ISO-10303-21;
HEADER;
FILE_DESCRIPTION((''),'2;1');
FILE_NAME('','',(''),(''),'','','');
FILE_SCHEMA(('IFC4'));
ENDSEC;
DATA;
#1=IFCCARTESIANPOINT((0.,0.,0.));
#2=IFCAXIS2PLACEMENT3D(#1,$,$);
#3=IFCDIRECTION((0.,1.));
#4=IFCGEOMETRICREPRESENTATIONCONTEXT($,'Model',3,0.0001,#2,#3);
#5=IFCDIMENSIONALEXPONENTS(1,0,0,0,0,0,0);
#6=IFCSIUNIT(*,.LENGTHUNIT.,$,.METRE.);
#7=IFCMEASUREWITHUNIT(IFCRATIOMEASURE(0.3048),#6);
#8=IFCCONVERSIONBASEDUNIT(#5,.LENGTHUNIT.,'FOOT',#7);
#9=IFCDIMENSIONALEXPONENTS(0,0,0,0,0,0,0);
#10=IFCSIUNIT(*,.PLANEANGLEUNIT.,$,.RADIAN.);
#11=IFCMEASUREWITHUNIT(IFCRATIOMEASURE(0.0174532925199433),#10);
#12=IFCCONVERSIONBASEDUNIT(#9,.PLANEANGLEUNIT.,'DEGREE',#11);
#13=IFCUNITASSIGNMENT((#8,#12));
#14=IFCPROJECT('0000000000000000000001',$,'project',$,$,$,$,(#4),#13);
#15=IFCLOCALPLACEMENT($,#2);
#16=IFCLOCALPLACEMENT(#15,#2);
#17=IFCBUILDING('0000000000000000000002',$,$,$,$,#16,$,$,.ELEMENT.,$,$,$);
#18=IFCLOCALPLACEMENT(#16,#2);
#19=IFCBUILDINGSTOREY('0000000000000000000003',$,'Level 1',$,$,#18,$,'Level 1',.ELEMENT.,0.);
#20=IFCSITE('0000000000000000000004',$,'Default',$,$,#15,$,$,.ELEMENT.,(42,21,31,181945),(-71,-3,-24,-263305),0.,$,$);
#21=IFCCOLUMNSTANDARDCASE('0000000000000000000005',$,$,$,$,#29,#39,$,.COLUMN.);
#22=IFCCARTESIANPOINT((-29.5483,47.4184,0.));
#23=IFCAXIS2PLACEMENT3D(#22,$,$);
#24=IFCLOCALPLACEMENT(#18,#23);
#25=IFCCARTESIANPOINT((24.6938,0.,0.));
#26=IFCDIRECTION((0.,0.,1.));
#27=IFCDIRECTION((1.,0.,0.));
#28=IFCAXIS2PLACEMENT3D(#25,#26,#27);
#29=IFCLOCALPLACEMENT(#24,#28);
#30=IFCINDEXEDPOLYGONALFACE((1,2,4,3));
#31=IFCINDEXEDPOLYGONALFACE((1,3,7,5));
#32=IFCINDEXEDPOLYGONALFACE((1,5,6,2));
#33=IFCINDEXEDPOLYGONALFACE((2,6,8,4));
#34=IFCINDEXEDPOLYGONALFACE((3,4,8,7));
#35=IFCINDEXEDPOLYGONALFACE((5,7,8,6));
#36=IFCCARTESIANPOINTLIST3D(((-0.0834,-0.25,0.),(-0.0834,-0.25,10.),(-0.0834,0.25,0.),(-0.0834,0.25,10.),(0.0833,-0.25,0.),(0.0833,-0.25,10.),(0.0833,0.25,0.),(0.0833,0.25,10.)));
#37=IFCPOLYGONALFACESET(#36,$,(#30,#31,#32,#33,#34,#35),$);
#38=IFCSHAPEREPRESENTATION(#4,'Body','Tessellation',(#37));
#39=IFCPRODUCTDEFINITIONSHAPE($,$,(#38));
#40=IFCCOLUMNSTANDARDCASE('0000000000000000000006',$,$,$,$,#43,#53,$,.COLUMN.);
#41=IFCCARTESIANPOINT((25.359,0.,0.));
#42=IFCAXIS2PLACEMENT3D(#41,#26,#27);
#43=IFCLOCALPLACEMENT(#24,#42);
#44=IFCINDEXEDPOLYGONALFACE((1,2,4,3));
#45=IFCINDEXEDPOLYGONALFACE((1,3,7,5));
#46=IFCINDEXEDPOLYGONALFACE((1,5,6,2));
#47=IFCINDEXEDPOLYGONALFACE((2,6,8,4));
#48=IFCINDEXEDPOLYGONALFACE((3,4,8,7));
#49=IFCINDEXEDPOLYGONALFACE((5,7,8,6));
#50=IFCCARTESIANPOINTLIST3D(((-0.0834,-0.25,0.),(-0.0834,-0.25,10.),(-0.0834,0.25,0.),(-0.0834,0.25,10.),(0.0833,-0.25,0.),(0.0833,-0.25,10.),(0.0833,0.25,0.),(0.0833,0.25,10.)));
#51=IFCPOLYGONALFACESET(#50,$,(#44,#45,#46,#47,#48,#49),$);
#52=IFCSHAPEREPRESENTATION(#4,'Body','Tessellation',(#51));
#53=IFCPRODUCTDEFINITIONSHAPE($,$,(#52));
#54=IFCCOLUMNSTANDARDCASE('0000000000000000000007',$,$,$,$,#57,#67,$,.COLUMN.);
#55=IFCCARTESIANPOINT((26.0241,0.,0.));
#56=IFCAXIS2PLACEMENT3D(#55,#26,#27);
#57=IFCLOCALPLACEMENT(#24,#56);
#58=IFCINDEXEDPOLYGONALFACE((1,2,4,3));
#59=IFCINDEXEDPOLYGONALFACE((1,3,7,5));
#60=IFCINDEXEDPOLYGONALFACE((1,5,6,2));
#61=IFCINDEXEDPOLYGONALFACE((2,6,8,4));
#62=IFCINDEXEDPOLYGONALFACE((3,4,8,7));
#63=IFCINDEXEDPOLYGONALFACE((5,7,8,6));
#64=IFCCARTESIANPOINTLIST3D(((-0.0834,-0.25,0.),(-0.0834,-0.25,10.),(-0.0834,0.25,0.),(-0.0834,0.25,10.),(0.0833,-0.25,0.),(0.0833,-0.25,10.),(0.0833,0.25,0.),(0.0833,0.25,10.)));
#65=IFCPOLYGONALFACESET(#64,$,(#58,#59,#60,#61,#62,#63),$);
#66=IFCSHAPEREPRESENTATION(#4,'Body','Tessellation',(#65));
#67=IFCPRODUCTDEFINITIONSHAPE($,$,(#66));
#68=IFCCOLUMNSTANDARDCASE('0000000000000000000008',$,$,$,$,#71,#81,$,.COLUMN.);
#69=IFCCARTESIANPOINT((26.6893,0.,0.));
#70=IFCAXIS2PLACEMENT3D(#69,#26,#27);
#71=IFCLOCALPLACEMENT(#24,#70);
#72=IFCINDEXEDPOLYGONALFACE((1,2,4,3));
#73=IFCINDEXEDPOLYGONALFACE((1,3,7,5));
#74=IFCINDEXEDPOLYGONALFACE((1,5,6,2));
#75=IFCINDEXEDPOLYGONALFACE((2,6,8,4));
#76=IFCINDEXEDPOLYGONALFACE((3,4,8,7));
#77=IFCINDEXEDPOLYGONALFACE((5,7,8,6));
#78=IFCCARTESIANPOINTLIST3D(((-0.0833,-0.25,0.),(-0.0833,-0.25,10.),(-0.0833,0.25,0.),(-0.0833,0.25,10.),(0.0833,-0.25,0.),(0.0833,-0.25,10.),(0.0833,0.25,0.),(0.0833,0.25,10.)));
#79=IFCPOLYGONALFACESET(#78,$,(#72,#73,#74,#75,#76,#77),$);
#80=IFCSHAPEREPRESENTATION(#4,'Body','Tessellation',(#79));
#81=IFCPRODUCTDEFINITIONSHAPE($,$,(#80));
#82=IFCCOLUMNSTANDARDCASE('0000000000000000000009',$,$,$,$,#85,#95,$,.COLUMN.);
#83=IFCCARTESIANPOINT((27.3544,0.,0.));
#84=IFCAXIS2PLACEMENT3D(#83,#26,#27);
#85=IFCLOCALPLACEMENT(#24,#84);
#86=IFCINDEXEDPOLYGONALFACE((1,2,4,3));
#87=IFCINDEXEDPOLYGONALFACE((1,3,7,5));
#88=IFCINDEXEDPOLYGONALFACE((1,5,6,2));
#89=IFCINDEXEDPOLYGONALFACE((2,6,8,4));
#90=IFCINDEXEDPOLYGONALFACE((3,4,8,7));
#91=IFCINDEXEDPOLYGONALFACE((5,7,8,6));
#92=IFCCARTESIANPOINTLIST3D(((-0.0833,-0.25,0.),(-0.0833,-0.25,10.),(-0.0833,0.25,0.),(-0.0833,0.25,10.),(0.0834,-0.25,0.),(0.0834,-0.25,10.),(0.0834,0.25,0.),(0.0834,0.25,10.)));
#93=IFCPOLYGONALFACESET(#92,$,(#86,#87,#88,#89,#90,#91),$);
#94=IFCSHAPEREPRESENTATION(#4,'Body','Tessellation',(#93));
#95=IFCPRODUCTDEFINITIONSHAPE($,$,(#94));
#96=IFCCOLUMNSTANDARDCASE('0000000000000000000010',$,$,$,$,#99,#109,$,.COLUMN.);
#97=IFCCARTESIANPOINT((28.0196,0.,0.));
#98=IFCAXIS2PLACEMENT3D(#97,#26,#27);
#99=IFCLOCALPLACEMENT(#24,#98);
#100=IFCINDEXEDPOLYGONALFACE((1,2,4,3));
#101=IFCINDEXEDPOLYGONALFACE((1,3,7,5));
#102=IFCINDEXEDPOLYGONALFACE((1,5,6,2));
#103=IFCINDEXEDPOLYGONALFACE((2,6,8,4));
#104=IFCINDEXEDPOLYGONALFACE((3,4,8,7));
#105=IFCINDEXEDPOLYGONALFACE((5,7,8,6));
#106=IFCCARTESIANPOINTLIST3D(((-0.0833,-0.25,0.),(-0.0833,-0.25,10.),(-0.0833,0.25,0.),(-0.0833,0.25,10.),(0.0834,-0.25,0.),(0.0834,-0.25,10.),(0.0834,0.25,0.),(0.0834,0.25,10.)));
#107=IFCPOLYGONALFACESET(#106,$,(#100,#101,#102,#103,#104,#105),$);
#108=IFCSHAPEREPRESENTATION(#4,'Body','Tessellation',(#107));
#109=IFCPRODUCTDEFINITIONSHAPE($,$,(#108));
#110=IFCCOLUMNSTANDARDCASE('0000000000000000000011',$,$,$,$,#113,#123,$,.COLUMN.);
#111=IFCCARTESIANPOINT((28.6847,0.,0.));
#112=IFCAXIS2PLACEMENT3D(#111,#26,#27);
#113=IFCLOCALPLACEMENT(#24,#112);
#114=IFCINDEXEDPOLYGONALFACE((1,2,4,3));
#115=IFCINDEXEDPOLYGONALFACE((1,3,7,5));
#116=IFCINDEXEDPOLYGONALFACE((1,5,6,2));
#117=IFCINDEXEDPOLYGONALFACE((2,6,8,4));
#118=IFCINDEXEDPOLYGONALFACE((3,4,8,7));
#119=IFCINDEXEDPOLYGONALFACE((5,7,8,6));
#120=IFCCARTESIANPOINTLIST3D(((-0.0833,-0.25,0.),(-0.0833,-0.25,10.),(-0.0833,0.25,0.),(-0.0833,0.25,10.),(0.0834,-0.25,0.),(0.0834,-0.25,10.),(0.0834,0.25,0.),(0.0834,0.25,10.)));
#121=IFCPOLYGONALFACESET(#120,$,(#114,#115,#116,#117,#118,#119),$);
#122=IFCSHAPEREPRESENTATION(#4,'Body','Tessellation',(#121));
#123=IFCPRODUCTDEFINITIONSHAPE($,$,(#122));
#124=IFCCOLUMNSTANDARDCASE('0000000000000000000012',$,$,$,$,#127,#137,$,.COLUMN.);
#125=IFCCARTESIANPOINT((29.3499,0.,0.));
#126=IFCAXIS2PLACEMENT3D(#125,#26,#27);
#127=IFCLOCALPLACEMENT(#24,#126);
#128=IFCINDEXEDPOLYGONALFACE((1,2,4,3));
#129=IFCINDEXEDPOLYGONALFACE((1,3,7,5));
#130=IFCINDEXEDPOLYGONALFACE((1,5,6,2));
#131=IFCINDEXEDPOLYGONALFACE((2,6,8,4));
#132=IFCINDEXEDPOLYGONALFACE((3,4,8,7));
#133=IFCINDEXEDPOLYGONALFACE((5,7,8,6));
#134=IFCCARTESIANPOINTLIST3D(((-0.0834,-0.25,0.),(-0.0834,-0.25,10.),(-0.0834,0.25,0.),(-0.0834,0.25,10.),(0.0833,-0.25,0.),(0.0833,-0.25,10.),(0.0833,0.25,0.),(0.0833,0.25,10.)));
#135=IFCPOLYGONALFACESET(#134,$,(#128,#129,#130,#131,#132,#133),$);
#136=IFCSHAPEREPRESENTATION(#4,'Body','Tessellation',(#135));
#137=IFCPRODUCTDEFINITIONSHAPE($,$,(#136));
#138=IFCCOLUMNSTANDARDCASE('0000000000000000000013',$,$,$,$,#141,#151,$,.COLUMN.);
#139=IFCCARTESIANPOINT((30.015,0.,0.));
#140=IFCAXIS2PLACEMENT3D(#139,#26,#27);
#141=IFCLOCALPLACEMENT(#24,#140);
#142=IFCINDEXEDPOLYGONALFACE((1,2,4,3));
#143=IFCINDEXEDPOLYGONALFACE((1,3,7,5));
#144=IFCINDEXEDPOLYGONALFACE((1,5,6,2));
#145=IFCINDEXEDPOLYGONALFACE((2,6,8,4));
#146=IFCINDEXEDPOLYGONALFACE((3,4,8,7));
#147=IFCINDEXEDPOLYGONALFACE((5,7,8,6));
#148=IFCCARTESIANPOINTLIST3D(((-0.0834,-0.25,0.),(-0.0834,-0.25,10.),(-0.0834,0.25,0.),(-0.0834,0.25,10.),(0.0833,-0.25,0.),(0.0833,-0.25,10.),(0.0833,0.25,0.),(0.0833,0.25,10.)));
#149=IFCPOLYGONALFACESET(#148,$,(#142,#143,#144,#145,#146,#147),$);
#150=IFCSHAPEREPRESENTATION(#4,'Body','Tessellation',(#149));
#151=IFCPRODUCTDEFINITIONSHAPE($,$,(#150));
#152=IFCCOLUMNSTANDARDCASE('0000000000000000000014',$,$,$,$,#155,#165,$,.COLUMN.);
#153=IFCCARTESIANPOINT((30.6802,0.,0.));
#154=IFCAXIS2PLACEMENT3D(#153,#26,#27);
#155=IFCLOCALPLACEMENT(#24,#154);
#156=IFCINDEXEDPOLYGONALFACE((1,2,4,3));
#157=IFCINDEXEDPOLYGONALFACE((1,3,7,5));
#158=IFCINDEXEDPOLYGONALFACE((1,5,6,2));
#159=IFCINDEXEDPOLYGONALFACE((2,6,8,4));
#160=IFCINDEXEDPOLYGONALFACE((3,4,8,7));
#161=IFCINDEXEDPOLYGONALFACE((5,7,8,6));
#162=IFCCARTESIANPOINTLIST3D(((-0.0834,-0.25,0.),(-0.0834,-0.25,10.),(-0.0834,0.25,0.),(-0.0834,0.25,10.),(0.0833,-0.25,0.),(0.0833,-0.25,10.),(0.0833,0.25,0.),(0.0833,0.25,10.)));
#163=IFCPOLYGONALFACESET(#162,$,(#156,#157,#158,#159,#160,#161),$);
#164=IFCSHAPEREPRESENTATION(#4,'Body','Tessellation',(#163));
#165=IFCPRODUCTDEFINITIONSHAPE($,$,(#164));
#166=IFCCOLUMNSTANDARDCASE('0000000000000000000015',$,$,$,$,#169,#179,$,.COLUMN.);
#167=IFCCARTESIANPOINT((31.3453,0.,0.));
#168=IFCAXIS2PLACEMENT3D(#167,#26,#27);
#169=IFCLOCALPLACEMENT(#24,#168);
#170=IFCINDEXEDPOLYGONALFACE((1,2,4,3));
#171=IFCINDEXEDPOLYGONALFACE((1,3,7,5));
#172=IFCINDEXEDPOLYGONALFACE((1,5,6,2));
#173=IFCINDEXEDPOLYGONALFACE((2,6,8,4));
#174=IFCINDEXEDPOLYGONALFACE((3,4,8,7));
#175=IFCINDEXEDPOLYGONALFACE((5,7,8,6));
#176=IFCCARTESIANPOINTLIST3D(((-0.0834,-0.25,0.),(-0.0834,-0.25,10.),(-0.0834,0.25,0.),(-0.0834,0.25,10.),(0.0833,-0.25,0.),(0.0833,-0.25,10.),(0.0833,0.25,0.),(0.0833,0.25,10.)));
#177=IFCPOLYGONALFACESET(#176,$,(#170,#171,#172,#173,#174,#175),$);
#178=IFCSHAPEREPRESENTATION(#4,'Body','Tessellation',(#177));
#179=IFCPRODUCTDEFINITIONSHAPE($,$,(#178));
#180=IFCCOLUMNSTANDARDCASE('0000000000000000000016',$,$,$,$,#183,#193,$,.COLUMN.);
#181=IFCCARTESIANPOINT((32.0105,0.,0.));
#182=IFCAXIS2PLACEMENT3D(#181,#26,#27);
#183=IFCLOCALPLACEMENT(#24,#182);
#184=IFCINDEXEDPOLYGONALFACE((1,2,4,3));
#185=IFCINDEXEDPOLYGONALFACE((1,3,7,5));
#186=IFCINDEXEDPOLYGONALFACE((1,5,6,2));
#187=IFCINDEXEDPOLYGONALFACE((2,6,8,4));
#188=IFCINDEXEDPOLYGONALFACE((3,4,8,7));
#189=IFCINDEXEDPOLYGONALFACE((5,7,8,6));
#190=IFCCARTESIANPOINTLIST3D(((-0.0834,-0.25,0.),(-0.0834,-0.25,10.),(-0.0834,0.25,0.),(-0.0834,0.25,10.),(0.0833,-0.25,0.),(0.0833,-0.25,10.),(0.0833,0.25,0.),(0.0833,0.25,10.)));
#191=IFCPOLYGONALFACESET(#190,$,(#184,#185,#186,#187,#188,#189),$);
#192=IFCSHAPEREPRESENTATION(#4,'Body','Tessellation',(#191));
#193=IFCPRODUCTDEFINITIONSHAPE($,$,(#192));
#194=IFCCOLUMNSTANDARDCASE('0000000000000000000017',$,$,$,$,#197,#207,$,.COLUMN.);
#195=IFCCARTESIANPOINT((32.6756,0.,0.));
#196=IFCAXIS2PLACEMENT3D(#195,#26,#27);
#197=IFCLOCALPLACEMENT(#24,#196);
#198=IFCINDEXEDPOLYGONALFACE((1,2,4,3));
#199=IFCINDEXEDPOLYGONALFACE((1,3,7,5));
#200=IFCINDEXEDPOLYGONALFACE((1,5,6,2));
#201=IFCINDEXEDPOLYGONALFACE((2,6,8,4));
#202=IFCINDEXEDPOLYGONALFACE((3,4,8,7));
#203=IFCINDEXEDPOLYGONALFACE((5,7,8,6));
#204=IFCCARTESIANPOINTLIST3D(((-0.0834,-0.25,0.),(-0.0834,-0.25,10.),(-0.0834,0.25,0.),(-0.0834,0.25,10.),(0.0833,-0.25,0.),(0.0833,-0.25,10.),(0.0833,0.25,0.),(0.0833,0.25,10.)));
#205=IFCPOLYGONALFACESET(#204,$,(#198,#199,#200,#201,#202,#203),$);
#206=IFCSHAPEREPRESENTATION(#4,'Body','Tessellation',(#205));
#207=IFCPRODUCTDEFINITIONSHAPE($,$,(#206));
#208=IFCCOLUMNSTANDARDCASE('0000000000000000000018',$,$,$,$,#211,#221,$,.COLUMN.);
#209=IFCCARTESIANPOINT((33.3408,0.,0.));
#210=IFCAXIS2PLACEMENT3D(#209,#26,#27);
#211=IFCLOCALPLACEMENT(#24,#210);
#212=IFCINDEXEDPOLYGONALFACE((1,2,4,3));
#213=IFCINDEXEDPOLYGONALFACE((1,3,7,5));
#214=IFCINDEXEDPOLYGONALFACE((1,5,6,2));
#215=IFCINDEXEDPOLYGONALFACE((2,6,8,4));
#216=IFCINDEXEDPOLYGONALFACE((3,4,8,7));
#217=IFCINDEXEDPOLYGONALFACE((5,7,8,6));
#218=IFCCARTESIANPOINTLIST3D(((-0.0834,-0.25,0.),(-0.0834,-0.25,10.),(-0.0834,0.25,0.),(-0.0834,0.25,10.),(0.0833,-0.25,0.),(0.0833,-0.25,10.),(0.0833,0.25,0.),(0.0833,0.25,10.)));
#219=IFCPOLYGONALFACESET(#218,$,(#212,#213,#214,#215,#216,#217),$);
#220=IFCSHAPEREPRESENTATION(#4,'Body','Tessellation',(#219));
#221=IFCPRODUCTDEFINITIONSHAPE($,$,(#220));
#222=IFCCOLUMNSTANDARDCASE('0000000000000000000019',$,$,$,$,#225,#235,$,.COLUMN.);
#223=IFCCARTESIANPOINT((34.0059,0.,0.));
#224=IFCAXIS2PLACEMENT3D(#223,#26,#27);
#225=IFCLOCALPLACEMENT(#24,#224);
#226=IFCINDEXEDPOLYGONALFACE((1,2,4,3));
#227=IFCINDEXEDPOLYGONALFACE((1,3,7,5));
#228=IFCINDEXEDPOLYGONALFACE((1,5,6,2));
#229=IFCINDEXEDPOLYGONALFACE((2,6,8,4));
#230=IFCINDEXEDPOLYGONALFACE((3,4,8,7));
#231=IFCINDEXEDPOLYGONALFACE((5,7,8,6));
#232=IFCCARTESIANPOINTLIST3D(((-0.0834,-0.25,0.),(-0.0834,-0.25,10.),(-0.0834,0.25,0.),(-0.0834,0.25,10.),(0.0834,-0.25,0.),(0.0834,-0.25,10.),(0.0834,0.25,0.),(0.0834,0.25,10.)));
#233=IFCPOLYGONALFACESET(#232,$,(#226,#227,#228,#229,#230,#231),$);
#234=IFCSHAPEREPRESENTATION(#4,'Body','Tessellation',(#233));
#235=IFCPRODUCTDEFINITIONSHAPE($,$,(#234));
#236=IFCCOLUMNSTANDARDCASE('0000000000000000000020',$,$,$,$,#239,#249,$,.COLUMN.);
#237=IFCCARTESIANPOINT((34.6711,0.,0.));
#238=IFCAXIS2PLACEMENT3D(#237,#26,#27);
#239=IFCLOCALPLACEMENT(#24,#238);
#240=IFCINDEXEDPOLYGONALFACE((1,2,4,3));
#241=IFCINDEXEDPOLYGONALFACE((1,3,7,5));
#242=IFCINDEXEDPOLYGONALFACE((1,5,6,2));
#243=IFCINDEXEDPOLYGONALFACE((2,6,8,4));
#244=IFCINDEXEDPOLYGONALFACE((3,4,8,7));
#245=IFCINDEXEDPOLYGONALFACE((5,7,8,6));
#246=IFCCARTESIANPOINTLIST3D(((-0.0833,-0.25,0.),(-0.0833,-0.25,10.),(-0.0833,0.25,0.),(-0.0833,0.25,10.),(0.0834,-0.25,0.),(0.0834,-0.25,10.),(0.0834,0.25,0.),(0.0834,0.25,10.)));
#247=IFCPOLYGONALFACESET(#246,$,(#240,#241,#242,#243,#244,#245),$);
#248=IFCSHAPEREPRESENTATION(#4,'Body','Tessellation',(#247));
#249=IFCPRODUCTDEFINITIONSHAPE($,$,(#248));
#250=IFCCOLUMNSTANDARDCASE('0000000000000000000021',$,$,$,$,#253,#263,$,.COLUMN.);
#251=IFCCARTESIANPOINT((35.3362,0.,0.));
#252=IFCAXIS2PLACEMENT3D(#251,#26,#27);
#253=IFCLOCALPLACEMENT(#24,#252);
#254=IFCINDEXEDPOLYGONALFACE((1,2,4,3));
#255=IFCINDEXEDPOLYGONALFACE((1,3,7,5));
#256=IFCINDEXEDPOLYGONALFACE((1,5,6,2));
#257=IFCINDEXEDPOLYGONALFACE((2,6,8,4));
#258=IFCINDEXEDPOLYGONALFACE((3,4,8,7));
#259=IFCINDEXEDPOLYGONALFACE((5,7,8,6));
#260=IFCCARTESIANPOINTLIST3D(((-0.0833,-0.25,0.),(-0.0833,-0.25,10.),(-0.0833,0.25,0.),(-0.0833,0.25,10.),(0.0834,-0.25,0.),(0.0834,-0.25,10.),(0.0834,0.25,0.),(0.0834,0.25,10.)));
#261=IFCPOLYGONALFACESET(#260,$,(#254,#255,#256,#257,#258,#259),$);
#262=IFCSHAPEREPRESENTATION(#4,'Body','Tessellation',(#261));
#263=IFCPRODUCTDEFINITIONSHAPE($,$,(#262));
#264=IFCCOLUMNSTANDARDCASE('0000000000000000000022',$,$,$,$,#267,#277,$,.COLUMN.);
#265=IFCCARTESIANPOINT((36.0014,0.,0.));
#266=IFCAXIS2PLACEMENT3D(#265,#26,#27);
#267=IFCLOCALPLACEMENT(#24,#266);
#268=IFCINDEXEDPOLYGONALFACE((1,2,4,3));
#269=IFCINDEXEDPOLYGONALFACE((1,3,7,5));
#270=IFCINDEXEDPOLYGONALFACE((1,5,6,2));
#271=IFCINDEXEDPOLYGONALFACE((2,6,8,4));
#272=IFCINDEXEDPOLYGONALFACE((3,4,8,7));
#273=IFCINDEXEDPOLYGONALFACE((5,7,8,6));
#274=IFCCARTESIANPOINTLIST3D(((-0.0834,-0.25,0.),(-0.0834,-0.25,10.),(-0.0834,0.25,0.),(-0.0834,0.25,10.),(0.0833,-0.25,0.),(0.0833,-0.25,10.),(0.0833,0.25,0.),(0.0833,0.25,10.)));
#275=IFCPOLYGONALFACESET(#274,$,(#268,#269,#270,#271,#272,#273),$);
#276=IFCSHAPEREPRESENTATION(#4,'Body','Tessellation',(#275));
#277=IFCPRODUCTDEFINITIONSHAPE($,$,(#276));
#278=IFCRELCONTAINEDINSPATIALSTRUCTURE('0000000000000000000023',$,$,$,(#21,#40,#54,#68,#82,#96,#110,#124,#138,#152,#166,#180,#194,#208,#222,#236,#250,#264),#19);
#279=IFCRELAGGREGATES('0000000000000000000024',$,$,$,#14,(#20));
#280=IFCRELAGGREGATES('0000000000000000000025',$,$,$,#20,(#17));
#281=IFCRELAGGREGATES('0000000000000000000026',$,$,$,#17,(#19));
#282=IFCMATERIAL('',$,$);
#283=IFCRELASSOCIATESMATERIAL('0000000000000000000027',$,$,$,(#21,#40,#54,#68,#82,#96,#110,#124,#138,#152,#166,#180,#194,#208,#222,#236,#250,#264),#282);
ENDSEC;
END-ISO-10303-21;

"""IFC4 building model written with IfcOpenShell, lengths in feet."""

from ifc_helpers import new_model, entity, si_unit, converted_unit, direction, frame, origin, place, context, project, spatial, rectangle, extrude, material, element, save


model = new_model("IFC4")

# Units and contexts
model_context = context("Model", 3, precision=0.0001, world=origin(), true_north=direction((0.0, 1.0)))
ifc_project = project(units=[converted_unit("LENGTHUNIT", "FOOT", entity("IfcRatioMeasure", 0.3048), si_unit("LENGTHUNIT", "METRE"), dimensions=[1, 0, 0, 0, 0, 0, 0]), converted_unit("PLANEANGLEUNIT", "DEGREE", entity("IfcRatioMeasure", 0.0174532925199433), si_unit("PLANEANGLEUNIT", "RADIAN"), dimensions=[0, 0, 0, 0, 0, 0, 0])], contexts=[model_context])

# Site, building, storey
site_placement = place(None, origin())
site = spatial("IfcSite", under=ifc_project, at=site_placement, Name="Default", CompositionType="ELEMENT", RefLatitude=(42, 21, 31, 181945), RefLongitude=(-71, -3, -24, -263305), RefElevation=0.0)
building_placement = place(site_placement, origin())
building = spatial("IfcBuilding", under=site, at=building_placement, CompositionType="ELEMENT")
storey_placement = place(building_placement, origin())
storey = spatial("IfcBuildingStorey", under=building, at=storey_placement, Name="Level 1", LongName="Level 1", CompositionType="ELEMENT", Elevation=0.0)

# Columns
ifc_material = material(Name="")
placement = place(storey_placement, frame((-29.5483, 47.4184, 0.0)))
for number, where, z_axis, x_axis in (
    (1, (24.6938, 0.0, 0.0), (0.0, 0.0, 1.0), (1.0, 0.0, 0.0)),
    (2, (25.359, 0.0, 0.0), (0.0, 0.0, 1.0), (1.0, 0.0, 0.0)),
    (3, (26.0241, 0.0, 0.0), (0.0, 0.0, 1.0), (1.0, 0.0, 0.0)),
    (4, (26.6893, 0.0, 0.0), (0.0, 0.0, 1.0), (1.0, 0.0, 0.0)),
    (5, (27.3544, 0.0, 0.0), (0.0, 0.0, 1.0), (1.0, 0.0, 0.0)),
    (6, (28.0196, 0.0, 0.0), (0.0, 0.0, 1.0), (1.0, 0.0, 0.0)),
    (7, (28.6847, 0.0, 0.0), (0.0, 0.0, 1.0), (1.0, 0.0, 0.0)),
    (8, (29.3499, 0.0, 0.0), (0.0, 0.0, 1.0), (1.0, 0.0, 0.0)),
    (9, (30.015, 0.0, 0.0), (0.0, 0.0, 1.0), (1.0, 0.0, 0.0)),
    (10, (30.6802, 0.0, 0.0), (0.0, 0.0, 1.0), (1.0, 0.0, 0.0)),
    (11, (31.3453, 0.0, 0.0), (0.0, 0.0, 1.0), (1.0, 0.0, 0.0)),
    (12, (32.0105, 0.0, 0.0), (0.0, 0.0, 1.0), (1.0, 0.0, 0.0)),
    (13, (32.6756, 0.0, 0.0), (0.0, 0.0, 1.0), (1.0, 0.0, 0.0)),
    (14, (33.3408, 0.0, 0.0), (0.0, 0.0, 1.0), (1.0, 0.0, 0.0)),
    (15, (34.0059, 0.0, 0.0), (0.0, 0.0, 1.0), (1.0, 0.0, 0.0)),
    (16, (34.6711, 0.0, 0.0), (0.0, 0.0, 1.0), (1.0, 0.0, 0.0)),
    (17, (35.3362, 0.0, 0.0), (0.0, 0.0, 1.0), (1.0, 0.0, 0.0)),
    (18, (36.0014, 0.0, 0.0), (0.0, 0.0, 1.0), (1.0, 0.0, 0.0)),
):
    element("IfcColumnStandardCase", number, at=place(placement, frame(where, z_axis=z_axis, x_axis=x_axis)), inside=storey, material=ifc_material, PredefinedType="COLUMN", context=model_context, shape_type="SweptSolid", body=[
        extrude(rectangle(XDim=0.1667, YDim=0.5), origin(), (0.0, 0.0, 1.0), 10.0),
    ])

save(model, "model.ifc")
